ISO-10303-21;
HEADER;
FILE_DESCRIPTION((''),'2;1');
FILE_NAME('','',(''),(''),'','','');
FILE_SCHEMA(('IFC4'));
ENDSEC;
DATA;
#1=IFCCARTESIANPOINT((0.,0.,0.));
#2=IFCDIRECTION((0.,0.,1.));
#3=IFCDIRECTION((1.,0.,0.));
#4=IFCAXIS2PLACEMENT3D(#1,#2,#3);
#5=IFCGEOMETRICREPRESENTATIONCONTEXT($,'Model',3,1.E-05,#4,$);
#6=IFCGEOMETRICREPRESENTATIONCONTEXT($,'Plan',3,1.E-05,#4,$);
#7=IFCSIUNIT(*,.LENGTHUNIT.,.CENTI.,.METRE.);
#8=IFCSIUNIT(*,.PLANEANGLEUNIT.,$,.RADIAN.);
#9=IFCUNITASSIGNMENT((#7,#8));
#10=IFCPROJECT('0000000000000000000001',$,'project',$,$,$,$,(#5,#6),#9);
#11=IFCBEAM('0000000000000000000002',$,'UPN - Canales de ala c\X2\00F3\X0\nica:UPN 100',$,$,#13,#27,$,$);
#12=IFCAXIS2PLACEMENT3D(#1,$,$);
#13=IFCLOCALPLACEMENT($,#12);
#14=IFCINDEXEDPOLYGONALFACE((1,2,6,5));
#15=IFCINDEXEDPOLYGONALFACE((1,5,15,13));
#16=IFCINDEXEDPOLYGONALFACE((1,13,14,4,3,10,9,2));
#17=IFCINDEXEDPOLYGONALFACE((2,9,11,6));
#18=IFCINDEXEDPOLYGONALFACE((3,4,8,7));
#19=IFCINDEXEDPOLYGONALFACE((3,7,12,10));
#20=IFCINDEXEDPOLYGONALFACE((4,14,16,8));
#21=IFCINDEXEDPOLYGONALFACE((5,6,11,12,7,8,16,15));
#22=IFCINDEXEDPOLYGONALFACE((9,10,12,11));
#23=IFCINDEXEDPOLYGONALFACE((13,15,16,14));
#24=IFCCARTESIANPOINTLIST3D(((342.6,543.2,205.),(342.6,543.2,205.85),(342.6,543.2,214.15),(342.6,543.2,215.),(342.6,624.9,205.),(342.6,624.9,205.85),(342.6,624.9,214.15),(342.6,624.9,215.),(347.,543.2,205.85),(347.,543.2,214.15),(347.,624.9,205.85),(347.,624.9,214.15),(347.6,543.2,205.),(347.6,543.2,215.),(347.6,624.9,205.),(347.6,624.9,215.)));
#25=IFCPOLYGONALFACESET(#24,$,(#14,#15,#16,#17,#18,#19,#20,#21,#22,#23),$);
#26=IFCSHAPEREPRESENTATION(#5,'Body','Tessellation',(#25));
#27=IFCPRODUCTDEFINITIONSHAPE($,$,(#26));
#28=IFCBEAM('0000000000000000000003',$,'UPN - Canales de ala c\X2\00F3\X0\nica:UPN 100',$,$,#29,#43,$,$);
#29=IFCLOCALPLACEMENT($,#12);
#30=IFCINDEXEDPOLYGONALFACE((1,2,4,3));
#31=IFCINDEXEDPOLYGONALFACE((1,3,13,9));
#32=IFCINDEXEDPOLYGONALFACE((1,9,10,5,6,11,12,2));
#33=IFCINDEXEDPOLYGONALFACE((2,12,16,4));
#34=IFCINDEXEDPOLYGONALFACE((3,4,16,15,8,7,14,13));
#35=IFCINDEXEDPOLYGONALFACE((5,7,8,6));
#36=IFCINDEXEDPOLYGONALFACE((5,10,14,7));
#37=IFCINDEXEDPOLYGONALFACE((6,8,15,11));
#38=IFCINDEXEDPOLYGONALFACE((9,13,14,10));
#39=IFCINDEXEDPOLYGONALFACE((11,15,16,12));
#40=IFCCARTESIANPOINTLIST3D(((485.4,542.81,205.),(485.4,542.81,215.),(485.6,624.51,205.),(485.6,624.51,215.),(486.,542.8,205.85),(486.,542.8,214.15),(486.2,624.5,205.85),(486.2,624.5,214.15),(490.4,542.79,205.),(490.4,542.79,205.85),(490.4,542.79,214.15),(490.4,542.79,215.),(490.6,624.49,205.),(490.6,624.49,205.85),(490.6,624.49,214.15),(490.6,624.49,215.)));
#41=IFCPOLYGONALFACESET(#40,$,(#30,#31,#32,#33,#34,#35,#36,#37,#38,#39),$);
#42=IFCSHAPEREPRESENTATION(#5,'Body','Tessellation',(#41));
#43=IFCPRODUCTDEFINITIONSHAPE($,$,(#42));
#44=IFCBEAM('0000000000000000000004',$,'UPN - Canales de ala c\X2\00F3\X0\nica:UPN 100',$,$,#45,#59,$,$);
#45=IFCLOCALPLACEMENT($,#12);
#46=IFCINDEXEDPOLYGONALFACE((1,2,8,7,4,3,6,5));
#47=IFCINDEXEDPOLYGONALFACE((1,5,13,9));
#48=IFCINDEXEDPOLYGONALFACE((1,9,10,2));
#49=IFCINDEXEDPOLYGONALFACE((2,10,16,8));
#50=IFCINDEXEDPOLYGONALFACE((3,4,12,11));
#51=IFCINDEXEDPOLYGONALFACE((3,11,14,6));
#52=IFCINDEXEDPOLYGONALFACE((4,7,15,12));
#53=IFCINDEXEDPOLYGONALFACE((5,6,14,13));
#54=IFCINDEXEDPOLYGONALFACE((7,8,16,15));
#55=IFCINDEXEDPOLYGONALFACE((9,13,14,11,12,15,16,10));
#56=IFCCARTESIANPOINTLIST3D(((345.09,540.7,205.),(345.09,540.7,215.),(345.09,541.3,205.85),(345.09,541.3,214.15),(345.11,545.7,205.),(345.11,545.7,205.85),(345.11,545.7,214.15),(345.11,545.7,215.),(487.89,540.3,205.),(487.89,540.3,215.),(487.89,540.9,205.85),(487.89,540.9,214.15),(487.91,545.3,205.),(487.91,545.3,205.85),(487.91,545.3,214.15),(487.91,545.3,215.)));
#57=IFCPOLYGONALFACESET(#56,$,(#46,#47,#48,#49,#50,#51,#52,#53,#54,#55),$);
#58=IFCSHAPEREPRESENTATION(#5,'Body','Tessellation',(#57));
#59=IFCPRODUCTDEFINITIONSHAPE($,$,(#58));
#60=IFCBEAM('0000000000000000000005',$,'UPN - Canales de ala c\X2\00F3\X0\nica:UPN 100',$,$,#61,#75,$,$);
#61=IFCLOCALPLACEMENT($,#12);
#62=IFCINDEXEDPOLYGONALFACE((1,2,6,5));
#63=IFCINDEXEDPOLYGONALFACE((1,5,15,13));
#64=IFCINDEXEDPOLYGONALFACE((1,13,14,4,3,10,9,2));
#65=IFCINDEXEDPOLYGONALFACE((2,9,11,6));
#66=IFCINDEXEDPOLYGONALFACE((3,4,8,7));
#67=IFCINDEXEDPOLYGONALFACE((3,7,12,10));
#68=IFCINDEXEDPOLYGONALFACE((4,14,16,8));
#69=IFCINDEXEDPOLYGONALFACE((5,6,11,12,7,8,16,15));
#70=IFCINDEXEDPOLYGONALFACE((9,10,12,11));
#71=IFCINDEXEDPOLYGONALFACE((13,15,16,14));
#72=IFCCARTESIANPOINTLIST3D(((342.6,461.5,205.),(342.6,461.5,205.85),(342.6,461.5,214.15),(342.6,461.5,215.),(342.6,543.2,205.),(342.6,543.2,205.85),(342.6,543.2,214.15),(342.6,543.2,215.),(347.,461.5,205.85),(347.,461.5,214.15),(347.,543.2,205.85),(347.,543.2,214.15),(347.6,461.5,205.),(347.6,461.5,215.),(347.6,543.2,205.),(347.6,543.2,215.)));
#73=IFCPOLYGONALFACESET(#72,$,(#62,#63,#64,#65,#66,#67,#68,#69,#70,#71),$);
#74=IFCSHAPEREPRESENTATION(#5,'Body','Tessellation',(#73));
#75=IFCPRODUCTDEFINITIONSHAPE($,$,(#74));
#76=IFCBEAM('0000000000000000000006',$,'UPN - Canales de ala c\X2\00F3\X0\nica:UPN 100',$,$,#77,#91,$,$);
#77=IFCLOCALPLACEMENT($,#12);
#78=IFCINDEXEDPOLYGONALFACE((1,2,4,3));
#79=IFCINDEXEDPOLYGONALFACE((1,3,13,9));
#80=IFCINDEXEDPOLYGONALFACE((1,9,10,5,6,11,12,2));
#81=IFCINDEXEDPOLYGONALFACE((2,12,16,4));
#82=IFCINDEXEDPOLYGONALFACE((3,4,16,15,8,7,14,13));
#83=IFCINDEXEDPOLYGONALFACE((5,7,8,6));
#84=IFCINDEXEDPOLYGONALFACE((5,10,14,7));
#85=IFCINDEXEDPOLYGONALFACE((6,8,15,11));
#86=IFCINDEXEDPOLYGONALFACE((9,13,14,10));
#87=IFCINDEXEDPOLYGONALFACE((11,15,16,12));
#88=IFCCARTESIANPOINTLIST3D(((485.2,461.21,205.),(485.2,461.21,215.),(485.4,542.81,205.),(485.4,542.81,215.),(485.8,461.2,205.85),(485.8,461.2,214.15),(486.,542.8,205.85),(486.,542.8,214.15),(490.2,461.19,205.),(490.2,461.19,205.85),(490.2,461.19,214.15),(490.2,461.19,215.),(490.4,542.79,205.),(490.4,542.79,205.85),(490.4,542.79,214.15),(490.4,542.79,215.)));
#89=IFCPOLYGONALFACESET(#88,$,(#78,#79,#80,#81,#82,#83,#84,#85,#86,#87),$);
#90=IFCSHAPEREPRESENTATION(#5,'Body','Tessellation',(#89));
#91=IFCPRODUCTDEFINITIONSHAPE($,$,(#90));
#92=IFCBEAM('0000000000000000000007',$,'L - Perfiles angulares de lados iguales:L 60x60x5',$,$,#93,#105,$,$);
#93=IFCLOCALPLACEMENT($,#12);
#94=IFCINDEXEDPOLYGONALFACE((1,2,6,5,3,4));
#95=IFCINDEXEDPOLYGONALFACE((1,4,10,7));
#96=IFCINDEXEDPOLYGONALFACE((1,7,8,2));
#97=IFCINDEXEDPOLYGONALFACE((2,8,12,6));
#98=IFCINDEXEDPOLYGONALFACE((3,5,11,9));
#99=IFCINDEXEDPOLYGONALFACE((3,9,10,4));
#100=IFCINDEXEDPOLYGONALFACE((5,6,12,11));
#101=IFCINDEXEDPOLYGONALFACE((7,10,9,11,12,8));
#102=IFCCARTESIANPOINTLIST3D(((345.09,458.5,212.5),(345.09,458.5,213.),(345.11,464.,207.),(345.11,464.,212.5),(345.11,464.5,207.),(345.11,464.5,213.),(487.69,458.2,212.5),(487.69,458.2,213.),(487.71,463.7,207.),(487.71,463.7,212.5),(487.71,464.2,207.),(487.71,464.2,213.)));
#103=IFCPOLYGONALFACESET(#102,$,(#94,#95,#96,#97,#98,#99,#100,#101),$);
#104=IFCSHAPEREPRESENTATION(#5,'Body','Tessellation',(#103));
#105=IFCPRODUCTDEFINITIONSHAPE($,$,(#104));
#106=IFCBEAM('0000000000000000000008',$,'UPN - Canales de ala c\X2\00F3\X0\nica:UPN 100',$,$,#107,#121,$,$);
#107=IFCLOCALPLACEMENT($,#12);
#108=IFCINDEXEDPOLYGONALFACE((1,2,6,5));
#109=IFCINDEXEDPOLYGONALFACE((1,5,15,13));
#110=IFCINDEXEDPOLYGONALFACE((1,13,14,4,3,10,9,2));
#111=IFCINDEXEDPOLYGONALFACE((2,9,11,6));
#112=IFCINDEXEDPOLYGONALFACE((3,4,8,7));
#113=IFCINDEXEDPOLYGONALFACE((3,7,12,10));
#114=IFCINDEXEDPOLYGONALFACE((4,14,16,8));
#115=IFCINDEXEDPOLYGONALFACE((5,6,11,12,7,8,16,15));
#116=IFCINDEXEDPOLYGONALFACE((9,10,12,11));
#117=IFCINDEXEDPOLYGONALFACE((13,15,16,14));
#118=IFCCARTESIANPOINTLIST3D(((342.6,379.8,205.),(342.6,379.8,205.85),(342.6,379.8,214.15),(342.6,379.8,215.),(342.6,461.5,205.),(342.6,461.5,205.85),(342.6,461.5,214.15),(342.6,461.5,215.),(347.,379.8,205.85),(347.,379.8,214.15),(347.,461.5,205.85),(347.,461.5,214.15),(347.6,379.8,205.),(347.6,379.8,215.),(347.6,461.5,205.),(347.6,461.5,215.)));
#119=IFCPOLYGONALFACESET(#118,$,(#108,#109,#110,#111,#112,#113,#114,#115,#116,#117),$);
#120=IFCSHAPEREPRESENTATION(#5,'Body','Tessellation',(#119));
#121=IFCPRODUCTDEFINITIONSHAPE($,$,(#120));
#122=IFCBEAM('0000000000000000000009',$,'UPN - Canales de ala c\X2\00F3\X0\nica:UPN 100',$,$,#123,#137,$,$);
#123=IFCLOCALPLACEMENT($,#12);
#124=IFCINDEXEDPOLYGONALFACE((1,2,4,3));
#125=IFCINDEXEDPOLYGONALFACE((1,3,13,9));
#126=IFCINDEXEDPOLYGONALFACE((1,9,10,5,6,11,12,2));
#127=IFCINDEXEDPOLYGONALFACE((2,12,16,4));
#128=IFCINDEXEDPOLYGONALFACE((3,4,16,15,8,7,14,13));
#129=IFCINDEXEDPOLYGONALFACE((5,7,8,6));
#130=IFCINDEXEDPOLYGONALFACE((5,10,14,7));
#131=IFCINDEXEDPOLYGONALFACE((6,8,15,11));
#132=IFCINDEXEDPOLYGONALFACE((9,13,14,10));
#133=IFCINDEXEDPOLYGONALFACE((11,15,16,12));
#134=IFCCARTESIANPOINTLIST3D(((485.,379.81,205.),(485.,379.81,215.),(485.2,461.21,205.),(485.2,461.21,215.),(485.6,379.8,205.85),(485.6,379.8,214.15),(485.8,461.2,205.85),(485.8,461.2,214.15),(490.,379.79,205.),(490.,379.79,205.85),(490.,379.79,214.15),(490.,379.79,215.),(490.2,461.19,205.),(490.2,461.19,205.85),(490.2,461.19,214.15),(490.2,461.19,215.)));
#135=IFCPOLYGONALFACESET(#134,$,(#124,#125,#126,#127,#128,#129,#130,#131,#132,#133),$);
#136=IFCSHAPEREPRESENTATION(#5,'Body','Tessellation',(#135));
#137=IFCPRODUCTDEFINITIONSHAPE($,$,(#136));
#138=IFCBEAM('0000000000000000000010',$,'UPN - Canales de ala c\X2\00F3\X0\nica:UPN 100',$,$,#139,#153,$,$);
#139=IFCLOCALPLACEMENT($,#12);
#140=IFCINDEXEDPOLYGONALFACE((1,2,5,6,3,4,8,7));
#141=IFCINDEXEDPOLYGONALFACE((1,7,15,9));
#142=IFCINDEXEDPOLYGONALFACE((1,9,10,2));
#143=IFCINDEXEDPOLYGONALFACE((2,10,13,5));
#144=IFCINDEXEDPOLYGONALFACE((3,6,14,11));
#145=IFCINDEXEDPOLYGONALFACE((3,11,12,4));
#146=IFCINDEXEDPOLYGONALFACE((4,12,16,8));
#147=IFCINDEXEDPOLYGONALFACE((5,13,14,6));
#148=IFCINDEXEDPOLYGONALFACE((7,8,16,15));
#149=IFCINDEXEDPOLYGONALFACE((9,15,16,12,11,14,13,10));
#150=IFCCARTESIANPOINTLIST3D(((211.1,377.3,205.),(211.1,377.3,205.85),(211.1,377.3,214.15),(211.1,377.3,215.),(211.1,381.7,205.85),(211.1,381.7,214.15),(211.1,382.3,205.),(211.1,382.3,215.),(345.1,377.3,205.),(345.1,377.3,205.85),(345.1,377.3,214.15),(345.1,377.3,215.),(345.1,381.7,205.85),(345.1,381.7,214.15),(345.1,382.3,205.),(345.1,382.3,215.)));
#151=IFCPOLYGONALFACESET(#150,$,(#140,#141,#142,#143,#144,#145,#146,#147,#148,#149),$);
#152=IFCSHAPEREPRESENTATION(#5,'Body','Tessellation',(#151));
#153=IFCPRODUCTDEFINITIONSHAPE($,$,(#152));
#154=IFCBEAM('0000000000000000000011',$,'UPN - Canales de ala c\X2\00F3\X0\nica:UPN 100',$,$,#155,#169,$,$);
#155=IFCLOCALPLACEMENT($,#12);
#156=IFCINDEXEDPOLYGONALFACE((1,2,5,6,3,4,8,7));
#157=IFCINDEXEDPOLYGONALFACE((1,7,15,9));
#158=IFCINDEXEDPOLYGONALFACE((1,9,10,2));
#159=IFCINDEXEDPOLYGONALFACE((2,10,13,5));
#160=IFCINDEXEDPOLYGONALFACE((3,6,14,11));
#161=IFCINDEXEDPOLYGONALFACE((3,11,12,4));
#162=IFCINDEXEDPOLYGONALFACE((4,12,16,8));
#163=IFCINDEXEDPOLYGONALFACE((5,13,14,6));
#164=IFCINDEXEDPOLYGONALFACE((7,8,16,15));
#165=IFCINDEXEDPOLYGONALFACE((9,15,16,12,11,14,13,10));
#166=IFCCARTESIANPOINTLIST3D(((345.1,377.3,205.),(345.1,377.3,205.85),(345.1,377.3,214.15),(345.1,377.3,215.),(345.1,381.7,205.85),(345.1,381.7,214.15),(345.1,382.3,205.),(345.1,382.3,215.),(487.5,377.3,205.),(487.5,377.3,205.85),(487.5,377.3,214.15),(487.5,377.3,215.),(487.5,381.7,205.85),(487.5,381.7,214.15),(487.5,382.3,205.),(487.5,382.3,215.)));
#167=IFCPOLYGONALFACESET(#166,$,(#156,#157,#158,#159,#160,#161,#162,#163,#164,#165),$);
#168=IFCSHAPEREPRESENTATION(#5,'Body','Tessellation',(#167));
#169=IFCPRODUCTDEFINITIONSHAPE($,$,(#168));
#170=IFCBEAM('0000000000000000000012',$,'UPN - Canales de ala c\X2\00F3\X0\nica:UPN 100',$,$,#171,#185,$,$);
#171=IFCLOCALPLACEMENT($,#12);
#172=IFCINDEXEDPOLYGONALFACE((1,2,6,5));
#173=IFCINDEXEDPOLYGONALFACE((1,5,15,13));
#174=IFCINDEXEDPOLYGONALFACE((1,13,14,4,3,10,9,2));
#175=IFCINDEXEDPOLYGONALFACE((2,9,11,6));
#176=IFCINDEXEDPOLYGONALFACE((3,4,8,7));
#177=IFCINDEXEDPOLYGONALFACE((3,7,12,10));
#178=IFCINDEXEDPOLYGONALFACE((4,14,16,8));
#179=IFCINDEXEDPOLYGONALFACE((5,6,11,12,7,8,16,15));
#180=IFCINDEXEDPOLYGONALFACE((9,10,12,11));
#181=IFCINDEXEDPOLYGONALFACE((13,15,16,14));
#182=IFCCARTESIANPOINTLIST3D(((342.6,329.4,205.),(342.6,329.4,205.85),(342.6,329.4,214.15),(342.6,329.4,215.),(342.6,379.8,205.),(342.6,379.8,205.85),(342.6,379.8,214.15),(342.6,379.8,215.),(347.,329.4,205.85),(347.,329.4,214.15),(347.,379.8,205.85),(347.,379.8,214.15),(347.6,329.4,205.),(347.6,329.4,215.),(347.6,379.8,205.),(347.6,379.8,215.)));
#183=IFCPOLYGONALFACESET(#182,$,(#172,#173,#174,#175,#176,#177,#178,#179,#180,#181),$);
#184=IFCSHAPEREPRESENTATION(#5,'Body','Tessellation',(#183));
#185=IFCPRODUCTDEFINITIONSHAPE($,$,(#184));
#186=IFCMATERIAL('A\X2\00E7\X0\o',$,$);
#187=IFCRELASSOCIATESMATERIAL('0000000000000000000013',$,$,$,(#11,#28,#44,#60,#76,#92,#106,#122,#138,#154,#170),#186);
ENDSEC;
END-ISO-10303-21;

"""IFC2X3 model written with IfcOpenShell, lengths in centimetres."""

from ifc_helpers import new_model, si_unit, frame, frame_2d, origin_with_axes, origin_2d_with_axis, place, context, project, polyline, u_section, outline, extrude, material, element, save


model = new_model("IFC2X3")

# Units and contexts
model_context = context("Model", 3, precision=1e-05, world=origin_with_axes())
plan_context = context("Plan", 3, precision=1e-05, world=origin_with_axes())
ifc_project = project(units=[si_unit("LENGTHUNIT", "METRE", prefix="CENTI"), si_unit("PLANEANGLEUNIT", "RADIAN")], contexts=[model_context, plan_context])

# Shared definitions
ifc_material = material(Name="Aço")

# Beams
beam_1_placement = place(None, frame((345.1, 543.2, 210.0), z_axis=(0.0, 1.0, 0.0), x_axis=(-1.0, 0.0, 0.0)))
element("IfcBeam", 1, at=beam_1_placement, material=ifc_material, Name="UPN - Canales de ala cónica:UPN 100", context=model_context, shape_type="SweptSolid", body=[
    extrude(u_section(Depth=10.0, FlangeWidth=5.0, WebThickness=0.6, FlangeThickness=0.85, FilletRadius=0.0, EdgeRadius=0.0, FlangeSlope=0.0, CentreOfGravityInX=0.0, at=origin_2d_with_axis()), origin_with_axes(), (0.0, 0.0, 1.0), 81.7),
])
beam_2_placement = place(None, frame((487.9, 542.8, 210.0), z_axis=(0.002448, 0.999997, 0.0), x_axis=(0.999997, -0.002448, 0.0)))
element("IfcBeam", 2, at=beam_2_placement, material=ifc_material, Name="UPN - Canales de ala cónica:UPN 100", context=model_context, shape_type="SweptSolid", body=[
    extrude(u_section(Depth=10.0, FlangeWidth=5.0, WebThickness=0.6, FlangeThickness=0.85, FilletRadius=0.0, EdgeRadius=0.0, FlangeSlope=0.0, CentreOfGravityInX=0.0, at=frame_2d((0.0, 0.0), x_axis=(1.0, 0.0))), origin_with_axes(), (0.0, 0.0, 1.0), 81.7),
])
beam_3_placement = place(None, frame((487.9, 542.8, 210.0), z_axis=(-0.999996, 0.002801, 0.0), x_axis=(0.002801, 0.999996, 0.0)))
element("IfcBeam", 3, at=beam_3_placement, material=ifc_material, Name="UPN - Canales de ala cónica:UPN 100", context=model_context, shape_type="SweptSolid", body=[
    extrude(u_section(Depth=10.0, FlangeWidth=5.0, WebThickness=0.6, FlangeThickness=0.85, FilletRadius=0.0, EdgeRadius=0.0, FlangeSlope=0.0, CentreOfGravityInX=0.0, at=frame_2d((0.0, 0.0), x_axis=(1.0, 0.0))), origin_with_axes(), (0.0, 0.0, 1.0), 142.8),
])
beam_4_placement = place(None, frame((345.1, 461.5, 210.0), z_axis=(0.0, 1.0, 0.0), x_axis=(-1.0, 0.0, 0.0)))
element("IfcBeam", 4, at=beam_4_placement, material=ifc_material, Name="UPN - Canales de ala cónica:UPN 100", context=model_context, shape_type="SweptSolid", body=[
    extrude(u_section(Depth=10.0, FlangeWidth=5.0, WebThickness=0.6, FlangeThickness=0.85, FilletRadius=0.0, EdgeRadius=0.0, FlangeSlope=0.0, CentreOfGravityInX=0.0, at=origin_2d_with_axis()), origin_with_axes(), (0.0, 0.0, 1.0), 81.7),
])
beam_5_placement = place(None, frame((487.7, 461.2, 210.0), z_axis=(0.002451, 0.999997, 0.0), x_axis=(0.999997, -0.002451, 0.0)))
element("IfcBeam", 5, at=beam_5_placement, material=ifc_material, Name="UPN - Canales de ala cónica:UPN 100", context=model_context, shape_type="SweptSolid", body=[
    extrude(u_section(Depth=10.0, FlangeWidth=5.0, WebThickness=0.6, FlangeThickness=0.85, FilletRadius=0.0, EdgeRadius=0.0, FlangeSlope=0.0, CentreOfGravityInX=0.0, at=frame_2d((0.0, 0.0), x_axis=(1.0, 0.0))), origin_with_axes(), (0.0, 0.0, 1.0), 81.6),
])
beam_6_placement = place(None, frame((487.7, 461.2, 210.0), z_axis=(-0.999998, 0.002104, 0.0), x_axis=(0.0, 0.0, 1.0)))
element("IfcBeam", 6, at=beam_6_placement, material=ifc_material, Name="L - Perfiles angulares de lados iguales:L 60x60x5", context=model_context, shape_type="SweptSolid", body=[
    extrude(outline(polyline([(3.0, -3.0), (3.0, 3.0), (-3.0, 3.0), (-3.0, 2.5), (2.5, 2.5), (2.5, -3.0), (3.0, -3.0)])), origin_with_axes(), (0.0, 0.0, 1.0), 142.6),
])
beam_7_placement = place(None, frame((345.1, 379.8, 210.0), z_axis=(0.0, 1.0, 0.0), x_axis=(-1.0, 0.0, 0.0)))
element("IfcBeam", 7, at=beam_7_placement, material=ifc_material, Name="UPN - Canales de ala cónica:UPN 100", context=model_context, shape_type="SweptSolid", body=[
    extrude(u_section(Depth=10.0, FlangeWidth=5.0, WebThickness=0.6, FlangeThickness=0.85, FilletRadius=0.0, EdgeRadius=0.0, FlangeSlope=0.0, CentreOfGravityInX=0.0, at=origin_2d_with_axis()), origin_with_axes(), (0.0, 0.0, 1.0), 81.7),
])
beam_8_placement = place(None, frame((487.5, 379.8, 210.0), z_axis=(0.002457, 0.999997, 0.0), x_axis=(0.999997, -0.002457, 0.0)))
element("IfcBeam", 8, at=beam_8_placement, material=ifc_material, Name="UPN - Canales de ala cónica:UPN 100", context=model_context, shape_type="SweptSolid", body=[
    extrude(u_section(Depth=10.0, FlangeWidth=5.0, WebThickness=0.6, FlangeThickness=0.85, FilletRadius=0.0, EdgeRadius=0.0, FlangeSlope=0.0, CentreOfGravityInX=0.0, at=frame_2d((0.0, 0.0), x_axis=(1.0, 0.0))), origin_with_axes(), (0.0, 0.0, 1.0), 81.4),
])
beam_9_placement = place(None, frame((345.1, 379.8, 210.0), z_axis=(-1.0, 0.0, 0.0), x_axis=(0.0, -1.0, 0.0)))
element("IfcBeam", 9, at=beam_9_placement, material=ifc_material, Name="UPN - Canales de ala cónica:UPN 100", context=model_context, shape_type="SweptSolid", body=[
    extrude(u_section(Depth=10.0, FlangeWidth=5.0, WebThickness=0.6, FlangeThickness=0.85, FilletRadius=0.0, EdgeRadius=0.0, FlangeSlope=0.0, CentreOfGravityInX=0.0, at=origin_2d_with_axis()), origin_with_axes(), (0.0, 0.0, 1.0), 134.0),
])
beam_10_placement = place(None, frame((487.5, 379.8, 210.0), z_axis=(-1.0, 0.0, 0.0), x_axis=(0.0, -1.0, 0.0)))
element("IfcBeam", 10, at=beam_10_placement, material=ifc_material, Name="UPN - Canales de ala cónica:UPN 100", context=model_context, shape_type="SweptSolid", body=[
    extrude(u_section(Depth=10.0, FlangeWidth=5.0, WebThickness=0.6, FlangeThickness=0.85, FilletRadius=0.0, EdgeRadius=0.0, FlangeSlope=0.0, CentreOfGravityInX=0.0, at=origin_2d_with_axis()), origin_with_axes(), (0.0, 0.0, 1.0), 142.4),
])
beam_11_placement = place(None, frame((345.1, 329.4, 210.0), z_axis=(0.0, 1.0, 0.0), x_axis=(-1.0, 0.0, 0.0)))
element("IfcBeam", 11, at=beam_11_placement, material=ifc_material, Name="UPN - Canales de ala cónica:UPN 100", context=model_context, shape_type="SweptSolid", body=[
    extrude(u_section(Depth=10.0, FlangeWidth=5.0, WebThickness=0.6, FlangeThickness=0.85, FilletRadius=0.0, EdgeRadius=0.0, FlangeSlope=0.0, CentreOfGravityInX=0.0, at=origin_2d_with_axis()), origin_with_axes(), (0.0, 0.0, 1.0), 50.4),
])

save(model, "model.ifc")
